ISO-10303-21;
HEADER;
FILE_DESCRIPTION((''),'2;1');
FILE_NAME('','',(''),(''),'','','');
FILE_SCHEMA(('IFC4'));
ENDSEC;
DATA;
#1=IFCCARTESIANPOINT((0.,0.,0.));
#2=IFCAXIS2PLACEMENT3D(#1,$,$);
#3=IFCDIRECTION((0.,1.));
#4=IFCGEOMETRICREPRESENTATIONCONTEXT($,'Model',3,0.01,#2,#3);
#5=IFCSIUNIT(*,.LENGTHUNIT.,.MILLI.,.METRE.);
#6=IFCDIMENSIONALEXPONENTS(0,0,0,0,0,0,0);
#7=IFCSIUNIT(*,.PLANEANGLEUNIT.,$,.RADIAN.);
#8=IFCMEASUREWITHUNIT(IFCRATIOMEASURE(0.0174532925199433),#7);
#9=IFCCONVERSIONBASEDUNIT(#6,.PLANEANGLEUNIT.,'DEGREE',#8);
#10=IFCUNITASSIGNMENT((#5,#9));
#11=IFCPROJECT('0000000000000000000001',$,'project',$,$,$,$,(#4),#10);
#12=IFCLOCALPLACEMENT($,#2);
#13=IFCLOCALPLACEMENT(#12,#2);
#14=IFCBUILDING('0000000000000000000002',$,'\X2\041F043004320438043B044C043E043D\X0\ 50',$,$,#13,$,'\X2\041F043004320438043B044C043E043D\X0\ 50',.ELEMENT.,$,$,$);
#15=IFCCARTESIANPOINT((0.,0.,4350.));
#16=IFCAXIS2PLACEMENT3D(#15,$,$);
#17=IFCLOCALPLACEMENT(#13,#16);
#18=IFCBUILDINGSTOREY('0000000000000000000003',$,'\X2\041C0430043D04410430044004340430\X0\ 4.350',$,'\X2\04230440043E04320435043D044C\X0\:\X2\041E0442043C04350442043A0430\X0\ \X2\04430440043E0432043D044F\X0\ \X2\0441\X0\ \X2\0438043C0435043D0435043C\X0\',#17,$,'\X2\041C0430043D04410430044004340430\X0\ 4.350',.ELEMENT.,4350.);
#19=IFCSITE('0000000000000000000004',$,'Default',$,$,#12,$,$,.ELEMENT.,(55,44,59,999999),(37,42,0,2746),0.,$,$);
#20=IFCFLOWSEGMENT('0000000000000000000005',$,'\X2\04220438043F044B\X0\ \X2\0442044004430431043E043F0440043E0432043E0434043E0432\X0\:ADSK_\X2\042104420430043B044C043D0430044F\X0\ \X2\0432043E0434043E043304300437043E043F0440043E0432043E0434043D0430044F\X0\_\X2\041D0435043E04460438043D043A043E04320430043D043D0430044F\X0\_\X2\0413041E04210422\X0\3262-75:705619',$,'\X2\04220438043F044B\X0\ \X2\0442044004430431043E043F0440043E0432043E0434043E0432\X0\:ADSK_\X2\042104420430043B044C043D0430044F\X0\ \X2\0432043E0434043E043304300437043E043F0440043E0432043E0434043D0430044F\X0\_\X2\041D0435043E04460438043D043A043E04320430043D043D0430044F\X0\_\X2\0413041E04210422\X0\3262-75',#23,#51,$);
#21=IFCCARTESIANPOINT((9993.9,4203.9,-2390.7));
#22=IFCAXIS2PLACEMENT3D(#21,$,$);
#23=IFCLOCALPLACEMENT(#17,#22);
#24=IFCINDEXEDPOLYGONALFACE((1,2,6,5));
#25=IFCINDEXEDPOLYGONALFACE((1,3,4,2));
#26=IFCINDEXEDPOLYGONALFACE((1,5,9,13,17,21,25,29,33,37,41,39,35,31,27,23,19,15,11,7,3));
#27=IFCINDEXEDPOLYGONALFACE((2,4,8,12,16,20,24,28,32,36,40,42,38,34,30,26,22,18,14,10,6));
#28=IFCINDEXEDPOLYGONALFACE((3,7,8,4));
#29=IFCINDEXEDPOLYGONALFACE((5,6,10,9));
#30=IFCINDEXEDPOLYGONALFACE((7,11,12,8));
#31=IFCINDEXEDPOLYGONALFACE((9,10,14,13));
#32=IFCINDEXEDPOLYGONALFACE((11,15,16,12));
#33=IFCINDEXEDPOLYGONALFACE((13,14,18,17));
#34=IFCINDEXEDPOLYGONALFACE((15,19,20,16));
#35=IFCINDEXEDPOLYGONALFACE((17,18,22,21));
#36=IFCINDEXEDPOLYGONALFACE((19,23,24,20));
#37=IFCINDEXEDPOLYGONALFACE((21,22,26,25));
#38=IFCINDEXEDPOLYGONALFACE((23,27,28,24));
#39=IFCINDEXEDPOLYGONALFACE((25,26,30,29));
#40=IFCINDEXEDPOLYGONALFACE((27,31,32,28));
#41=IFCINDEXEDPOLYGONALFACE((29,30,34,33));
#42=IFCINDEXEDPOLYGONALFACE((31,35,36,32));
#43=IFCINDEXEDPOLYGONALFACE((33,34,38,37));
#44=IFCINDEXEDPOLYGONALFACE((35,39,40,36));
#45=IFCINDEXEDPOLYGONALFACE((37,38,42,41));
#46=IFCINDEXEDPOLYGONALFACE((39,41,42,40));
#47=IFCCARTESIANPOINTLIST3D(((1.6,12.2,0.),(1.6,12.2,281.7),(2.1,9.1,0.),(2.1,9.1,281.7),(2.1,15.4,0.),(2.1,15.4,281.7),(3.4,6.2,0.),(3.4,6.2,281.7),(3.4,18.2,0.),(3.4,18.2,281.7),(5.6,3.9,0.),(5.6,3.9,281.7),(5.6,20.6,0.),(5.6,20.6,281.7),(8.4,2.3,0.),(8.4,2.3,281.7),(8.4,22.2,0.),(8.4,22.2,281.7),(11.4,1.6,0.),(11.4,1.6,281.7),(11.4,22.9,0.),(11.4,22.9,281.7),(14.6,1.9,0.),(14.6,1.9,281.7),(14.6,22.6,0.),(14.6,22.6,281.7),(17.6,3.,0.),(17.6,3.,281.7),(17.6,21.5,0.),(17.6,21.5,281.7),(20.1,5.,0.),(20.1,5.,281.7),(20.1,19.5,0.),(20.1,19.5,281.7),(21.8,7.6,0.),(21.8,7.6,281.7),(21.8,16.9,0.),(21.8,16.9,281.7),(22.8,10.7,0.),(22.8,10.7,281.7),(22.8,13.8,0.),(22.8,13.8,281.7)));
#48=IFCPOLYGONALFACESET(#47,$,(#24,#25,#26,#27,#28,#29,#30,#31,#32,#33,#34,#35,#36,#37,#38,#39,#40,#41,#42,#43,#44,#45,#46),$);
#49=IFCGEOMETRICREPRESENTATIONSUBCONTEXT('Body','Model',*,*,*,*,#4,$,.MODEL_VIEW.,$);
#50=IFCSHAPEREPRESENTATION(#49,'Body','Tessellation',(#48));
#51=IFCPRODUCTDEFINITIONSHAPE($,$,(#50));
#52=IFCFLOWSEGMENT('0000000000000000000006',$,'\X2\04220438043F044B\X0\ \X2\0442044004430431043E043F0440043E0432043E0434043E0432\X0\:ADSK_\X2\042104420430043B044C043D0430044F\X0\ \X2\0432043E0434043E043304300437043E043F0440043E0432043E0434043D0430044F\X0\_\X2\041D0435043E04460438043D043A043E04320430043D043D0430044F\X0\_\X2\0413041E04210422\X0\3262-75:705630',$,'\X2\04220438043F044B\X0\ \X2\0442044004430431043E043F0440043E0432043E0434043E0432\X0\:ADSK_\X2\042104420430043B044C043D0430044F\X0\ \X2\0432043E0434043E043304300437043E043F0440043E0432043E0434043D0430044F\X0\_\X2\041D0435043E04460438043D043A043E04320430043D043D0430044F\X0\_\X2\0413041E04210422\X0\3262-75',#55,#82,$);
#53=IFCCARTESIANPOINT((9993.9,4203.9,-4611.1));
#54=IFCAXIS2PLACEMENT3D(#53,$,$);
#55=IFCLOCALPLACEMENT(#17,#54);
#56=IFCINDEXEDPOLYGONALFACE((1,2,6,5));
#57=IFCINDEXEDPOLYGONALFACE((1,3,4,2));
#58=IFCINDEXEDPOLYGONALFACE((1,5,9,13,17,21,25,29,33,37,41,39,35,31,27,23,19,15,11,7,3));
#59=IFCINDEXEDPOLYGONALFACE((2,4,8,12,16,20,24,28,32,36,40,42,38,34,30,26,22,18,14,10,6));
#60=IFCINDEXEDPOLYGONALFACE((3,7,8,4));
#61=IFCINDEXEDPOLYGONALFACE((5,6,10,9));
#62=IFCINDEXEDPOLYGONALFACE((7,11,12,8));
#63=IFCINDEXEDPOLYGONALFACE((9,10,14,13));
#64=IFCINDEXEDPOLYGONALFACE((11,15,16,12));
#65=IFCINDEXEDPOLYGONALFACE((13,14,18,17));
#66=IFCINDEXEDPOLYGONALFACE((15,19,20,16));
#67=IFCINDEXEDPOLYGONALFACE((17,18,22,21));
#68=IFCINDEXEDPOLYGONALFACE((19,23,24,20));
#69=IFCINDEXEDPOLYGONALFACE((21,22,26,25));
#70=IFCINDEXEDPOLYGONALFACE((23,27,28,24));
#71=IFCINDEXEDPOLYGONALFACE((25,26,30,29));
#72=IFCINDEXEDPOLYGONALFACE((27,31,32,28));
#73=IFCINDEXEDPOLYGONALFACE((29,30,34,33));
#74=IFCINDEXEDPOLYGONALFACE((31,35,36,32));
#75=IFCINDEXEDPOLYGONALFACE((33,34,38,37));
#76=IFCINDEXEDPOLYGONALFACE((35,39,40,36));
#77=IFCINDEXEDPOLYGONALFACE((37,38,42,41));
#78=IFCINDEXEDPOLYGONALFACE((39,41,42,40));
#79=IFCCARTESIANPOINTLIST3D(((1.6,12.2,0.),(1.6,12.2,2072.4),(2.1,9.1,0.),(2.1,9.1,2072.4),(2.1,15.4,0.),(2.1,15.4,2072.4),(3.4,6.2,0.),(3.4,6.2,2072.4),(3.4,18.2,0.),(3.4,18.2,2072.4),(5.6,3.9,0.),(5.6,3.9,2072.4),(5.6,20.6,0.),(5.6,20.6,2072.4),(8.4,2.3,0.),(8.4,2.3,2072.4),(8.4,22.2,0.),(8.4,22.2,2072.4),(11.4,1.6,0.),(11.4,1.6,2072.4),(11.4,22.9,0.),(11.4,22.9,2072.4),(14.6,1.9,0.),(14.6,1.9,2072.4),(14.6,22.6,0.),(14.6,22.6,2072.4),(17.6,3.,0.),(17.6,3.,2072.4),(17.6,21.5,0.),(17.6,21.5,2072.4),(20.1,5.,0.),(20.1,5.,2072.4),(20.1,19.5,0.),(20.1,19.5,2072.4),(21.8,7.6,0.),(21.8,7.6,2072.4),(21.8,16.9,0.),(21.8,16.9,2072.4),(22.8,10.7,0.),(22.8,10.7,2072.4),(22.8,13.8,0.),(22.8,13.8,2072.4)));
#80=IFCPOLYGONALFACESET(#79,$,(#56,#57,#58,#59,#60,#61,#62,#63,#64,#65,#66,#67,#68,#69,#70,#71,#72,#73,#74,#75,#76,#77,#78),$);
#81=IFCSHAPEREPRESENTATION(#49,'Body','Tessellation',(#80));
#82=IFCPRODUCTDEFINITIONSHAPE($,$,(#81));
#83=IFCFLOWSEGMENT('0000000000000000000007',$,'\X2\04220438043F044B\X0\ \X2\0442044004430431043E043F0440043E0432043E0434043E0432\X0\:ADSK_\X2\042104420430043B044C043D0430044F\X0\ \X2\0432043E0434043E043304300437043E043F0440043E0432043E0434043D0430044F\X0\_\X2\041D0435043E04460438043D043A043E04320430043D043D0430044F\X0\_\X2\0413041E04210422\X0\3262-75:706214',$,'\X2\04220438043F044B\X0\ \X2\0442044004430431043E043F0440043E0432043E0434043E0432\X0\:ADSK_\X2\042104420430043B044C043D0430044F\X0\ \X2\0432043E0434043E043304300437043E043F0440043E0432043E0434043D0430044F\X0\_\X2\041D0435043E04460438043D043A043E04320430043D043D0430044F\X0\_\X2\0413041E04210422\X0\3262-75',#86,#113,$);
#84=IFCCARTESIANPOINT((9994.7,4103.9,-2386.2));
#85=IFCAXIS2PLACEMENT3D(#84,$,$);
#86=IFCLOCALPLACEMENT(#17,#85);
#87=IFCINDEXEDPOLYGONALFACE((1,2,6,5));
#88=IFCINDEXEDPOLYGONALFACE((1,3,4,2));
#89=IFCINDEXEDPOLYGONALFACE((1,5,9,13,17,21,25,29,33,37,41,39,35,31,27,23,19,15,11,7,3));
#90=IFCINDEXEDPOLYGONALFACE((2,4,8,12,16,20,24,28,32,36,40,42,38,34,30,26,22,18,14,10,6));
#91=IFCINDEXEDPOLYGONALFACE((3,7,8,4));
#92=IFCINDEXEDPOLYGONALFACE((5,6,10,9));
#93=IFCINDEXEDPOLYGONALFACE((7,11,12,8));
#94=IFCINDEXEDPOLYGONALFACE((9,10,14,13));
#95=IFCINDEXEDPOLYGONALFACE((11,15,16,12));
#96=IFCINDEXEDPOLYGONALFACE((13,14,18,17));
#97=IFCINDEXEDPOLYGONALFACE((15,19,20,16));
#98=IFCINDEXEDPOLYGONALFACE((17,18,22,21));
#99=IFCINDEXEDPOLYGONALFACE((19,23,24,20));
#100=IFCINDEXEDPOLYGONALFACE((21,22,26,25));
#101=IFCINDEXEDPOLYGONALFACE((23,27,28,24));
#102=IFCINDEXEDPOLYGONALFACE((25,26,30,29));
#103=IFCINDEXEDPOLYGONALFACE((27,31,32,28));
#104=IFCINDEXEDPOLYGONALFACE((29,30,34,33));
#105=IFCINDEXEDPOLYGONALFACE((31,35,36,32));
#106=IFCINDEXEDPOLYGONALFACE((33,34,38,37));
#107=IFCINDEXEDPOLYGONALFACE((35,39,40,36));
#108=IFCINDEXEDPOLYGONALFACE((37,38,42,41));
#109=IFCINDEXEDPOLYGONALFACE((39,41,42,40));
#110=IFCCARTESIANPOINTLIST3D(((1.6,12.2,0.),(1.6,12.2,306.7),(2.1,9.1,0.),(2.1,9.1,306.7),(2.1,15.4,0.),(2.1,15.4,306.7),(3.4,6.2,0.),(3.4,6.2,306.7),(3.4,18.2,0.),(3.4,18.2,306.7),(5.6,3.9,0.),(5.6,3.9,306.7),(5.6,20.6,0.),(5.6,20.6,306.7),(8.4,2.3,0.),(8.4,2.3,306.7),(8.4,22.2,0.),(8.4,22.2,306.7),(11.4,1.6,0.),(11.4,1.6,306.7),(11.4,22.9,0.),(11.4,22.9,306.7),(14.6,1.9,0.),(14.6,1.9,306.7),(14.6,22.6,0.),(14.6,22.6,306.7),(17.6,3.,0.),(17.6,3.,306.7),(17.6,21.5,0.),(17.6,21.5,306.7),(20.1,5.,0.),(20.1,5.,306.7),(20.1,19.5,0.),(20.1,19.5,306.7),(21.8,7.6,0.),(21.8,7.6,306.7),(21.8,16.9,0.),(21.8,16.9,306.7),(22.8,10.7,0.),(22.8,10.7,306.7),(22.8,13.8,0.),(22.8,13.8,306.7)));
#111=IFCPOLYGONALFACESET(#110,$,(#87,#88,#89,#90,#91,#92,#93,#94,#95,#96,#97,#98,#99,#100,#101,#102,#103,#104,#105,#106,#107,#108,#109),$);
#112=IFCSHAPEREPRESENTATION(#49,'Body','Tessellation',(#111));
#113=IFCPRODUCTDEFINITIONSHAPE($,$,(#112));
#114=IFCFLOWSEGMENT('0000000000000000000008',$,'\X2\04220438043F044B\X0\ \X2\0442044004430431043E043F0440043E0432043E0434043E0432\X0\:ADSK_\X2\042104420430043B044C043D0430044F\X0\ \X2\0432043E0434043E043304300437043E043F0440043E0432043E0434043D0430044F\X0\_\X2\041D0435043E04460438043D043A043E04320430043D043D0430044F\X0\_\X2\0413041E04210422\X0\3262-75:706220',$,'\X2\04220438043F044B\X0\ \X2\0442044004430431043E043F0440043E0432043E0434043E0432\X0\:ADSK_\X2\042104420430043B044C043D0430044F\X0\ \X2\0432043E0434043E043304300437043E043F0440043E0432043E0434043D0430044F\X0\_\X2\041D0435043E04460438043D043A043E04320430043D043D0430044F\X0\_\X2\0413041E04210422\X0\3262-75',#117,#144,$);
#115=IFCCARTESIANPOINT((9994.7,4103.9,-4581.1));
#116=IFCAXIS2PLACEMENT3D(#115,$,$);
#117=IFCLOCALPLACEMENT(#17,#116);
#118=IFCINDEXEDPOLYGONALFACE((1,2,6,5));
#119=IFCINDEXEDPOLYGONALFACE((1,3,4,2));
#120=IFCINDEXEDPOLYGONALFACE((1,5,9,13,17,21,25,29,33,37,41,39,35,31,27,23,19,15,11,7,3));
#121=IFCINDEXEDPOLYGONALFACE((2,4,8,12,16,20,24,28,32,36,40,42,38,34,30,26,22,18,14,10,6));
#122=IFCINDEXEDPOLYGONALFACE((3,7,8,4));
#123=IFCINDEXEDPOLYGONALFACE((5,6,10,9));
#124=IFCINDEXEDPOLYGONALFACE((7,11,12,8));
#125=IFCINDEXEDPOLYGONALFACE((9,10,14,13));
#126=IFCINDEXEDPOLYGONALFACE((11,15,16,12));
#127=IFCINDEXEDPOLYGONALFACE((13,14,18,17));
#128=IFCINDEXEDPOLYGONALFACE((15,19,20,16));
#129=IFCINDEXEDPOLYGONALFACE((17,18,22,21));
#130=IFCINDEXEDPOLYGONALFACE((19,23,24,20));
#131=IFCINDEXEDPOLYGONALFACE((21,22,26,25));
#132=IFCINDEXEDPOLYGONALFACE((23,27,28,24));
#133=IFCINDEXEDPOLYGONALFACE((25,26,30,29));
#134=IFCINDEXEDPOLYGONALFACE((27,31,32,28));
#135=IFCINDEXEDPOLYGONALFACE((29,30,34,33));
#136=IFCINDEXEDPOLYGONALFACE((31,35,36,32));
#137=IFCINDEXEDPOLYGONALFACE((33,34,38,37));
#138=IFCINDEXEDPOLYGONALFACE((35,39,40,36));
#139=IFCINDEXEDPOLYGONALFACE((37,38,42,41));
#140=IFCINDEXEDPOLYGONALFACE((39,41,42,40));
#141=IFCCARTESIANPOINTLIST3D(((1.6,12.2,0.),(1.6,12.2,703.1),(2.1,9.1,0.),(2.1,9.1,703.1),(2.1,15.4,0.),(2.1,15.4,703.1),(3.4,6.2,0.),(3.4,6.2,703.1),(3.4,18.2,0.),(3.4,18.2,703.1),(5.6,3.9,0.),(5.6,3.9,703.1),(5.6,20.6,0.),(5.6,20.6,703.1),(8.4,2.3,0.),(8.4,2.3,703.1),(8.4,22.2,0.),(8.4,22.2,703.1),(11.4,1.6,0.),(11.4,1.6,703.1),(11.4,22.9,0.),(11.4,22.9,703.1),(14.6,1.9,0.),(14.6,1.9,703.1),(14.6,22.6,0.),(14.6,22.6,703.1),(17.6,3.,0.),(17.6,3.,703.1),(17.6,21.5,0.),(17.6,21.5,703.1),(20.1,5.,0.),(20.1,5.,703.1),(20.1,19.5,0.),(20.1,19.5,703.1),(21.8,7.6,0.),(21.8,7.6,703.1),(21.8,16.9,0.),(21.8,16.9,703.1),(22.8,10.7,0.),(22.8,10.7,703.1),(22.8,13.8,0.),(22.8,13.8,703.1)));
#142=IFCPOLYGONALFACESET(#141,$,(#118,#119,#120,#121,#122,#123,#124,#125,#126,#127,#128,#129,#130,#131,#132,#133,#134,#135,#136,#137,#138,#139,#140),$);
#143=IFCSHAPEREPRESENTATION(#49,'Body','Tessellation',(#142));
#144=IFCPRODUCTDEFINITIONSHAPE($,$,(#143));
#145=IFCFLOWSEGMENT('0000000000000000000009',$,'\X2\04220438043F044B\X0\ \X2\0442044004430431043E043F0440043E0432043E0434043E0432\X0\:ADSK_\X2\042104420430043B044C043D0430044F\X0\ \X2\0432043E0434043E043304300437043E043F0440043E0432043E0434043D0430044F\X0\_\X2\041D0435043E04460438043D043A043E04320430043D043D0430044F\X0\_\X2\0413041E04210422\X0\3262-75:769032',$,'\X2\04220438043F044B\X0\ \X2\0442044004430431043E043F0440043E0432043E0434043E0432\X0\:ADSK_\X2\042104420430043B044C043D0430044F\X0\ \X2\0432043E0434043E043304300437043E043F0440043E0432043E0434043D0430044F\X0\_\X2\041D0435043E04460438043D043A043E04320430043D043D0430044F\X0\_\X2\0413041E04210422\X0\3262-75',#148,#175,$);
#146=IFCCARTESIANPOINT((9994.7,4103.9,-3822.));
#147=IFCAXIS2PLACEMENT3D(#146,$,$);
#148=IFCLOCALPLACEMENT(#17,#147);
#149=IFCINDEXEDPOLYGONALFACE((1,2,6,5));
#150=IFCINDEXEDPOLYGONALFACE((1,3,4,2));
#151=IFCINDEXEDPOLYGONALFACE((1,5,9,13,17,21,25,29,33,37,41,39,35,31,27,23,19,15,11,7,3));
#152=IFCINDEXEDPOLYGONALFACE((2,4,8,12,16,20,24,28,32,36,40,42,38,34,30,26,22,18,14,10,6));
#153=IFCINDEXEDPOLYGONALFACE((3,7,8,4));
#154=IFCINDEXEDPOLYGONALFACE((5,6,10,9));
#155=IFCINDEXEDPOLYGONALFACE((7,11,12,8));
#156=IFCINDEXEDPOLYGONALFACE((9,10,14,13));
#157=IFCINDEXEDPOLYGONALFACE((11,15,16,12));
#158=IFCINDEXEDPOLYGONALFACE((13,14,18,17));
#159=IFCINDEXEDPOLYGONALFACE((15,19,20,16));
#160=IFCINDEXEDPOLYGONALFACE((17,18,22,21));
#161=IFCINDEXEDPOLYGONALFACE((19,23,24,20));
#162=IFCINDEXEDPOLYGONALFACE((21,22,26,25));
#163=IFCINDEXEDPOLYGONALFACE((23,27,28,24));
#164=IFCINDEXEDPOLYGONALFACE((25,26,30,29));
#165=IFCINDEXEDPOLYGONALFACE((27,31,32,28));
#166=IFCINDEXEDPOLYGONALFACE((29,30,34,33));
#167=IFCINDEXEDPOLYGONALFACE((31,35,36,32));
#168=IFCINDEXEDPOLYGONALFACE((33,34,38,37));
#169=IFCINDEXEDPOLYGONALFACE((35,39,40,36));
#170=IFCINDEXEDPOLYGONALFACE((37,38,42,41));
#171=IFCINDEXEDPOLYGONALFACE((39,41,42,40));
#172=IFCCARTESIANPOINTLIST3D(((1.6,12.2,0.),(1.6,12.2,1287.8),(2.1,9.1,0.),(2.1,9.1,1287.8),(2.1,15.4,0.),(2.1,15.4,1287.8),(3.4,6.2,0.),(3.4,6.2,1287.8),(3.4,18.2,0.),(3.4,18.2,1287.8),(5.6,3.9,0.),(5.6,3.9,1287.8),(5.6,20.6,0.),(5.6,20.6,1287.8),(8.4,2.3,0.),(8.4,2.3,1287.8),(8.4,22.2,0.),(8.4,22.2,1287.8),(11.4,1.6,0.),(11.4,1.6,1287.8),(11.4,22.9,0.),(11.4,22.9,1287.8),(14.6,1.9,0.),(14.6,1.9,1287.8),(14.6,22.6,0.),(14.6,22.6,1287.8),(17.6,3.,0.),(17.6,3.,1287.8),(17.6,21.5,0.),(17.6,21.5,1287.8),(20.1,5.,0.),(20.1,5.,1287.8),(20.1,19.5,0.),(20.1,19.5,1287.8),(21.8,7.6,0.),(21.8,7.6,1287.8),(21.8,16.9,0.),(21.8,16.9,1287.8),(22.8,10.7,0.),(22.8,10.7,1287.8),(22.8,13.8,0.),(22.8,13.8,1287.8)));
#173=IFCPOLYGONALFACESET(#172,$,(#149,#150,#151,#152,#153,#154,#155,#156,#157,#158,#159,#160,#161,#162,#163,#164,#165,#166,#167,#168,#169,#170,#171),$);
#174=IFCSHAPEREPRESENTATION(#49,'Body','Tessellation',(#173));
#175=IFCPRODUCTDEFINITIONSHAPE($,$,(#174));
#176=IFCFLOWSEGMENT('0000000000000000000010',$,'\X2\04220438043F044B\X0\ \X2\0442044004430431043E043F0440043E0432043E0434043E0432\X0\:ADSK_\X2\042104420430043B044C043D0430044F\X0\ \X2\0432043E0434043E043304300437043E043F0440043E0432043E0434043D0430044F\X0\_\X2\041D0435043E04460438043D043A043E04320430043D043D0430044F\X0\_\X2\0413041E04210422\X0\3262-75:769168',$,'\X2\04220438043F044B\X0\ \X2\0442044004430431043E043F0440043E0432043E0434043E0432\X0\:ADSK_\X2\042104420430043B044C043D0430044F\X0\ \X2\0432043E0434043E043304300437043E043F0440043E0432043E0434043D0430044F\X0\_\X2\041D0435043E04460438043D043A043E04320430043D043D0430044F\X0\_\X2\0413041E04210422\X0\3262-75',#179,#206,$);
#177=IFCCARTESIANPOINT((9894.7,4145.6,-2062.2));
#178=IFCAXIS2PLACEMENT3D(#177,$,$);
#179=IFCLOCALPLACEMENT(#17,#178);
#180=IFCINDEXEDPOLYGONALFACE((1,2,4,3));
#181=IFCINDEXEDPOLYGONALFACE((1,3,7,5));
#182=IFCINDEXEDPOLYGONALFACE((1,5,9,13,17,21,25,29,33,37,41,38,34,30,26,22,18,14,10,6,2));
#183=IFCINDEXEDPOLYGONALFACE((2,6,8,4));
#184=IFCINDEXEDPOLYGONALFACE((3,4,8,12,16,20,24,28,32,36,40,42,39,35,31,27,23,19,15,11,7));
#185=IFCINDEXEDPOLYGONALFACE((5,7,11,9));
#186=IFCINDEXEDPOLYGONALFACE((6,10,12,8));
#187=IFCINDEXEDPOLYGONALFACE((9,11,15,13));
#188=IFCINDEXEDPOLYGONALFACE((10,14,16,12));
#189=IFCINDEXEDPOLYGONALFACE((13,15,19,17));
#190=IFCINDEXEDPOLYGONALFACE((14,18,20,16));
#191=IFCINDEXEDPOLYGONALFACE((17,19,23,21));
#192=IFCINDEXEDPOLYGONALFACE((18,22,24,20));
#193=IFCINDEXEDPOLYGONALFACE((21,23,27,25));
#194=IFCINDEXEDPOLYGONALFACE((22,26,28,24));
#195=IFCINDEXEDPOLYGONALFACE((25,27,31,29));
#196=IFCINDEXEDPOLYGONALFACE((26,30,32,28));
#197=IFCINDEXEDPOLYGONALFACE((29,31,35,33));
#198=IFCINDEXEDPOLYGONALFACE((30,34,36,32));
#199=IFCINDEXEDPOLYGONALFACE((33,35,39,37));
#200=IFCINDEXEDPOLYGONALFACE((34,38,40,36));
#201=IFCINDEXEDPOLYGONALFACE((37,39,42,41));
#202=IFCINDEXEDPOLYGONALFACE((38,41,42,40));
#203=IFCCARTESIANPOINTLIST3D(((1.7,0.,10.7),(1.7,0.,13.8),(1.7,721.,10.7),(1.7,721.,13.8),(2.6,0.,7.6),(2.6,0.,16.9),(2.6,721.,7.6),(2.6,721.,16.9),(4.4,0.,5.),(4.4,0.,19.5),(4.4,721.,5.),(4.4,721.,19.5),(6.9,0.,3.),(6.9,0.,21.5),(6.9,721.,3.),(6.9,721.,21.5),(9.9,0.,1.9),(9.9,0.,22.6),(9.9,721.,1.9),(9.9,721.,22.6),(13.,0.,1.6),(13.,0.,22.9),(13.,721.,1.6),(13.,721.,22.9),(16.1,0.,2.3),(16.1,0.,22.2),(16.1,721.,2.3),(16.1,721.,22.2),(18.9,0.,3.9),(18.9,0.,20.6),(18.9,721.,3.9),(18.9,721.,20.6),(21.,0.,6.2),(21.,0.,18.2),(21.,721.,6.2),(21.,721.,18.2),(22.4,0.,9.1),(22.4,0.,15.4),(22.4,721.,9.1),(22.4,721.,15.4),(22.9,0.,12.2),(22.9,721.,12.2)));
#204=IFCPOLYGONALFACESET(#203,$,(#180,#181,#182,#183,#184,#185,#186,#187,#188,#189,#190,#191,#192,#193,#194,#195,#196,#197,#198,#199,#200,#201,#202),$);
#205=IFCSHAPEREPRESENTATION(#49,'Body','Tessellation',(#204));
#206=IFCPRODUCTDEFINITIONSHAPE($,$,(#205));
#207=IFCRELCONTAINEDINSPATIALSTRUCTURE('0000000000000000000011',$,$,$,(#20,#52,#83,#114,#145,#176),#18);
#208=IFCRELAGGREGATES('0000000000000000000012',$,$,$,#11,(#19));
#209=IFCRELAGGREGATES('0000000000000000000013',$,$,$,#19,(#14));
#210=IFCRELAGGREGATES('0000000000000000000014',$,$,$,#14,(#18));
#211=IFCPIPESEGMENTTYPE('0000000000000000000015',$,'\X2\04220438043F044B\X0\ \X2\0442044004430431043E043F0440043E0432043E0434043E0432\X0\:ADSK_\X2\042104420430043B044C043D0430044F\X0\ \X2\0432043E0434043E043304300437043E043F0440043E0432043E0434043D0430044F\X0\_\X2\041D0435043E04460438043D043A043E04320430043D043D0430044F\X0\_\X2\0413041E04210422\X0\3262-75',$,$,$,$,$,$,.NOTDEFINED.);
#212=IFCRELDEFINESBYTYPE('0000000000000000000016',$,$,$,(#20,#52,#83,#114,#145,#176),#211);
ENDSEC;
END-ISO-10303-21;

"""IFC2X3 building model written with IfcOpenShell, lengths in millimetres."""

from ifc_helpers import new_model, entity, si_unit, converted_unit, direction, frame, origin, origin_2d_with_axis, place, context, subcontext, project, spatial, circle, extrude, type_object, element, save


model = new_model("IFC2X3")

# Units and contexts
model_context = context("Model", 3, precision=0.01, world=origin(), true_north=direction((0.0, 1.0)))
body_context = subcontext(model_context, "Body", "Model", "MODEL_VIEW")
ifc_project = project(units=[si_unit("LENGTHUNIT", "METRE", prefix="MILLI"), converted_unit("PLANEANGLEUNIT", "DEGREE", entity("IfcRatioMeasure", 0.0174532925199433), si_unit("PLANEANGLEUNIT", "RADIAN"), dimensions=[0, 0, 0, 0, 0, 0, 0])], contexts=[model_context])

# Site, building, storey
site_placement = place(None, origin())
site = spatial("IfcSite", under=ifc_project, at=site_placement, Name="Default", CompositionType="ELEMENT", RefLatitude=(55, 44, 59, 999999), RefLongitude=(37, 42, 0, 2746), RefElevation=0.0)
building_placement = place(site_placement, origin())
building = spatial("IfcBuilding", under=site, at=building_placement, Name="Павильон 50", LongName="Павильон 50", CompositionType="ELEMENT")
storey_placement = place(building_placement, frame((0.0, 0.0, 4350.0)))
storey = spatial("IfcBuildingStorey", under=building, at=storey_placement, Name="Мансарда 4.350", ObjectType="Уровень:Отметка уровня с именем", LongName="Мансарда 4.350", CompositionType="ELEMENT", Elevation=4350.0)

# Flow segments
pipe_segment_type = type_object("IfcPipeSegmentType", Name="Типы трубопроводов:ADSK_Стальная водогазопроводная_Неоцинкованная_ГОСТ3262-75", PredefinedType="NOTDEFINED")
flow_segment_1_placement = place(storey_placement, frame((9993.9, 4203.9, -2390.7)))
element("IfcFlowSegment", 1, at=flow_segment_1_placement, inside=storey, type_object=pipe_segment_type, Name="Типы трубопроводов:ADSK_Стальная водогазопроводная_Неоцинкованная_ГОСТ3262-75:705619", ObjectType="Типы трубопроводов:ADSK_Стальная водогазопроводная_Неоцинкованная_ГОСТ3262-75", context=body_context, shape_type="SweptSolid", body=[
    extrude(circle(Radius=10.7, at=origin_2d_with_axis()), frame((12.2, 12.2, 0.0), z_axis=(0.0, 0.0, 1.0), x_axis=(-1.0, 0.0, 0.0)), (0.0, 0.0, 1.0), 281.7),
])
flow_segment_2_placement = place(storey_placement, frame((9993.9, 4203.9, -4611.1)))
element("IfcFlowSegment", 2, at=flow_segment_2_placement, inside=storey, type_object=pipe_segment_type, Name="Типы трубопроводов:ADSK_Стальная водогазопроводная_Неоцинкованная_ГОСТ3262-75:705630", ObjectType="Типы трубопроводов:ADSK_Стальная водогазопроводная_Неоцинкованная_ГОСТ3262-75", context=body_context, shape_type="SweptSolid", body=[
    extrude(circle(Radius=10.7, at=origin_2d_with_axis()), frame((12.2, 12.2, 0.0), z_axis=(0.0, 0.0, 1.0), x_axis=(-1.0, 0.0, 0.0)), (0.0, 0.0, 1.0), 2072.4),
])
flow_segment_3_placement = place(storey_placement, frame((9994.7, 4103.9, -2386.2)))
element("IfcFlowSegment", 3, at=flow_segment_3_placement, inside=storey, type_object=pipe_segment_type, Name="Типы трубопроводов:ADSK_Стальная водогазопроводная_Неоцинкованная_ГОСТ3262-75:706214", ObjectType="Типы трубопроводов:ADSK_Стальная водогазопроводная_Неоцинкованная_ГОСТ3262-75", context=body_context, shape_type="SweptSolid", body=[
    extrude(circle(Radius=10.7, at=origin_2d_with_axis()), frame((12.2, 12.2, 0.0), z_axis=(0.0, 0.0, 1.0), x_axis=(-1.0, 0.0, 0.0)), (0.0, 0.0, 1.0), 306.7),
])
flow_segment_4_placement = place(storey_placement, frame((9994.7, 4103.9, -4581.1)))
element("IfcFlowSegment", 4, at=flow_segment_4_placement, inside=storey, type_object=pipe_segment_type, Name="Типы трубопроводов:ADSK_Стальная водогазопроводная_Неоцинкованная_ГОСТ3262-75:706220", ObjectType="Типы трубопроводов:ADSK_Стальная водогазопроводная_Неоцинкованная_ГОСТ3262-75", context=body_context, shape_type="SweptSolid", body=[
    extrude(circle(Radius=10.7, at=origin_2d_with_axis()), frame((12.2, 12.2, 0.0), z_axis=(0.0, 0.0, 1.0), x_axis=(-1.0, 0.0, 0.0)), (0.0, 0.0, 1.0), 703.1),
])
flow_segment_5_placement = place(storey_placement, frame((9994.7, 4103.9, -3822.0)))
element("IfcFlowSegment", 5, at=flow_segment_5_placement, inside=storey, type_object=pipe_segment_type, Name="Типы трубопроводов:ADSK_Стальная водогазопроводная_Неоцинкованная_ГОСТ3262-75:769032", ObjectType="Типы трубопроводов:ADSK_Стальная водогазопроводная_Неоцинкованная_ГОСТ3262-75", context=body_context, shape_type="SweptSolid", body=[
    extrude(circle(Radius=10.7, at=origin_2d_with_axis()), frame((12.2, 12.2, 0.0), z_axis=(0.0, 0.0, 1.0), x_axis=(-1.0, 0.0, 0.0)), (0.0, 0.0, 1.0), 1287.8),
])
flow_segment_6_placement = place(storey_placement, frame((9894.7, 4145.6, -2062.2)))
element("IfcFlowSegment", 6, at=flow_segment_6_placement, inside=storey, type_object=pipe_segment_type, Name="Типы трубопроводов:ADSK_Стальная водогазопроводная_Неоцинкованная_ГОСТ3262-75:769168", ObjectType="Типы трубопроводов:ADSK_Стальная водогазопроводная_Неоцинкованная_ГОСТ3262-75", context=body_context, shape_type="SweptSolid", body=[
    extrude(circle(Radius=10.7, at=origin_2d_with_axis()), frame((12.2, 0.0, 12.2), z_axis=(0.0, 1.0, 0.0), x_axis=(1.0, 0.0, 0.0)), (0.0, 0.0, 1.0), 721.0),
])

save(model, "model.ifc")
